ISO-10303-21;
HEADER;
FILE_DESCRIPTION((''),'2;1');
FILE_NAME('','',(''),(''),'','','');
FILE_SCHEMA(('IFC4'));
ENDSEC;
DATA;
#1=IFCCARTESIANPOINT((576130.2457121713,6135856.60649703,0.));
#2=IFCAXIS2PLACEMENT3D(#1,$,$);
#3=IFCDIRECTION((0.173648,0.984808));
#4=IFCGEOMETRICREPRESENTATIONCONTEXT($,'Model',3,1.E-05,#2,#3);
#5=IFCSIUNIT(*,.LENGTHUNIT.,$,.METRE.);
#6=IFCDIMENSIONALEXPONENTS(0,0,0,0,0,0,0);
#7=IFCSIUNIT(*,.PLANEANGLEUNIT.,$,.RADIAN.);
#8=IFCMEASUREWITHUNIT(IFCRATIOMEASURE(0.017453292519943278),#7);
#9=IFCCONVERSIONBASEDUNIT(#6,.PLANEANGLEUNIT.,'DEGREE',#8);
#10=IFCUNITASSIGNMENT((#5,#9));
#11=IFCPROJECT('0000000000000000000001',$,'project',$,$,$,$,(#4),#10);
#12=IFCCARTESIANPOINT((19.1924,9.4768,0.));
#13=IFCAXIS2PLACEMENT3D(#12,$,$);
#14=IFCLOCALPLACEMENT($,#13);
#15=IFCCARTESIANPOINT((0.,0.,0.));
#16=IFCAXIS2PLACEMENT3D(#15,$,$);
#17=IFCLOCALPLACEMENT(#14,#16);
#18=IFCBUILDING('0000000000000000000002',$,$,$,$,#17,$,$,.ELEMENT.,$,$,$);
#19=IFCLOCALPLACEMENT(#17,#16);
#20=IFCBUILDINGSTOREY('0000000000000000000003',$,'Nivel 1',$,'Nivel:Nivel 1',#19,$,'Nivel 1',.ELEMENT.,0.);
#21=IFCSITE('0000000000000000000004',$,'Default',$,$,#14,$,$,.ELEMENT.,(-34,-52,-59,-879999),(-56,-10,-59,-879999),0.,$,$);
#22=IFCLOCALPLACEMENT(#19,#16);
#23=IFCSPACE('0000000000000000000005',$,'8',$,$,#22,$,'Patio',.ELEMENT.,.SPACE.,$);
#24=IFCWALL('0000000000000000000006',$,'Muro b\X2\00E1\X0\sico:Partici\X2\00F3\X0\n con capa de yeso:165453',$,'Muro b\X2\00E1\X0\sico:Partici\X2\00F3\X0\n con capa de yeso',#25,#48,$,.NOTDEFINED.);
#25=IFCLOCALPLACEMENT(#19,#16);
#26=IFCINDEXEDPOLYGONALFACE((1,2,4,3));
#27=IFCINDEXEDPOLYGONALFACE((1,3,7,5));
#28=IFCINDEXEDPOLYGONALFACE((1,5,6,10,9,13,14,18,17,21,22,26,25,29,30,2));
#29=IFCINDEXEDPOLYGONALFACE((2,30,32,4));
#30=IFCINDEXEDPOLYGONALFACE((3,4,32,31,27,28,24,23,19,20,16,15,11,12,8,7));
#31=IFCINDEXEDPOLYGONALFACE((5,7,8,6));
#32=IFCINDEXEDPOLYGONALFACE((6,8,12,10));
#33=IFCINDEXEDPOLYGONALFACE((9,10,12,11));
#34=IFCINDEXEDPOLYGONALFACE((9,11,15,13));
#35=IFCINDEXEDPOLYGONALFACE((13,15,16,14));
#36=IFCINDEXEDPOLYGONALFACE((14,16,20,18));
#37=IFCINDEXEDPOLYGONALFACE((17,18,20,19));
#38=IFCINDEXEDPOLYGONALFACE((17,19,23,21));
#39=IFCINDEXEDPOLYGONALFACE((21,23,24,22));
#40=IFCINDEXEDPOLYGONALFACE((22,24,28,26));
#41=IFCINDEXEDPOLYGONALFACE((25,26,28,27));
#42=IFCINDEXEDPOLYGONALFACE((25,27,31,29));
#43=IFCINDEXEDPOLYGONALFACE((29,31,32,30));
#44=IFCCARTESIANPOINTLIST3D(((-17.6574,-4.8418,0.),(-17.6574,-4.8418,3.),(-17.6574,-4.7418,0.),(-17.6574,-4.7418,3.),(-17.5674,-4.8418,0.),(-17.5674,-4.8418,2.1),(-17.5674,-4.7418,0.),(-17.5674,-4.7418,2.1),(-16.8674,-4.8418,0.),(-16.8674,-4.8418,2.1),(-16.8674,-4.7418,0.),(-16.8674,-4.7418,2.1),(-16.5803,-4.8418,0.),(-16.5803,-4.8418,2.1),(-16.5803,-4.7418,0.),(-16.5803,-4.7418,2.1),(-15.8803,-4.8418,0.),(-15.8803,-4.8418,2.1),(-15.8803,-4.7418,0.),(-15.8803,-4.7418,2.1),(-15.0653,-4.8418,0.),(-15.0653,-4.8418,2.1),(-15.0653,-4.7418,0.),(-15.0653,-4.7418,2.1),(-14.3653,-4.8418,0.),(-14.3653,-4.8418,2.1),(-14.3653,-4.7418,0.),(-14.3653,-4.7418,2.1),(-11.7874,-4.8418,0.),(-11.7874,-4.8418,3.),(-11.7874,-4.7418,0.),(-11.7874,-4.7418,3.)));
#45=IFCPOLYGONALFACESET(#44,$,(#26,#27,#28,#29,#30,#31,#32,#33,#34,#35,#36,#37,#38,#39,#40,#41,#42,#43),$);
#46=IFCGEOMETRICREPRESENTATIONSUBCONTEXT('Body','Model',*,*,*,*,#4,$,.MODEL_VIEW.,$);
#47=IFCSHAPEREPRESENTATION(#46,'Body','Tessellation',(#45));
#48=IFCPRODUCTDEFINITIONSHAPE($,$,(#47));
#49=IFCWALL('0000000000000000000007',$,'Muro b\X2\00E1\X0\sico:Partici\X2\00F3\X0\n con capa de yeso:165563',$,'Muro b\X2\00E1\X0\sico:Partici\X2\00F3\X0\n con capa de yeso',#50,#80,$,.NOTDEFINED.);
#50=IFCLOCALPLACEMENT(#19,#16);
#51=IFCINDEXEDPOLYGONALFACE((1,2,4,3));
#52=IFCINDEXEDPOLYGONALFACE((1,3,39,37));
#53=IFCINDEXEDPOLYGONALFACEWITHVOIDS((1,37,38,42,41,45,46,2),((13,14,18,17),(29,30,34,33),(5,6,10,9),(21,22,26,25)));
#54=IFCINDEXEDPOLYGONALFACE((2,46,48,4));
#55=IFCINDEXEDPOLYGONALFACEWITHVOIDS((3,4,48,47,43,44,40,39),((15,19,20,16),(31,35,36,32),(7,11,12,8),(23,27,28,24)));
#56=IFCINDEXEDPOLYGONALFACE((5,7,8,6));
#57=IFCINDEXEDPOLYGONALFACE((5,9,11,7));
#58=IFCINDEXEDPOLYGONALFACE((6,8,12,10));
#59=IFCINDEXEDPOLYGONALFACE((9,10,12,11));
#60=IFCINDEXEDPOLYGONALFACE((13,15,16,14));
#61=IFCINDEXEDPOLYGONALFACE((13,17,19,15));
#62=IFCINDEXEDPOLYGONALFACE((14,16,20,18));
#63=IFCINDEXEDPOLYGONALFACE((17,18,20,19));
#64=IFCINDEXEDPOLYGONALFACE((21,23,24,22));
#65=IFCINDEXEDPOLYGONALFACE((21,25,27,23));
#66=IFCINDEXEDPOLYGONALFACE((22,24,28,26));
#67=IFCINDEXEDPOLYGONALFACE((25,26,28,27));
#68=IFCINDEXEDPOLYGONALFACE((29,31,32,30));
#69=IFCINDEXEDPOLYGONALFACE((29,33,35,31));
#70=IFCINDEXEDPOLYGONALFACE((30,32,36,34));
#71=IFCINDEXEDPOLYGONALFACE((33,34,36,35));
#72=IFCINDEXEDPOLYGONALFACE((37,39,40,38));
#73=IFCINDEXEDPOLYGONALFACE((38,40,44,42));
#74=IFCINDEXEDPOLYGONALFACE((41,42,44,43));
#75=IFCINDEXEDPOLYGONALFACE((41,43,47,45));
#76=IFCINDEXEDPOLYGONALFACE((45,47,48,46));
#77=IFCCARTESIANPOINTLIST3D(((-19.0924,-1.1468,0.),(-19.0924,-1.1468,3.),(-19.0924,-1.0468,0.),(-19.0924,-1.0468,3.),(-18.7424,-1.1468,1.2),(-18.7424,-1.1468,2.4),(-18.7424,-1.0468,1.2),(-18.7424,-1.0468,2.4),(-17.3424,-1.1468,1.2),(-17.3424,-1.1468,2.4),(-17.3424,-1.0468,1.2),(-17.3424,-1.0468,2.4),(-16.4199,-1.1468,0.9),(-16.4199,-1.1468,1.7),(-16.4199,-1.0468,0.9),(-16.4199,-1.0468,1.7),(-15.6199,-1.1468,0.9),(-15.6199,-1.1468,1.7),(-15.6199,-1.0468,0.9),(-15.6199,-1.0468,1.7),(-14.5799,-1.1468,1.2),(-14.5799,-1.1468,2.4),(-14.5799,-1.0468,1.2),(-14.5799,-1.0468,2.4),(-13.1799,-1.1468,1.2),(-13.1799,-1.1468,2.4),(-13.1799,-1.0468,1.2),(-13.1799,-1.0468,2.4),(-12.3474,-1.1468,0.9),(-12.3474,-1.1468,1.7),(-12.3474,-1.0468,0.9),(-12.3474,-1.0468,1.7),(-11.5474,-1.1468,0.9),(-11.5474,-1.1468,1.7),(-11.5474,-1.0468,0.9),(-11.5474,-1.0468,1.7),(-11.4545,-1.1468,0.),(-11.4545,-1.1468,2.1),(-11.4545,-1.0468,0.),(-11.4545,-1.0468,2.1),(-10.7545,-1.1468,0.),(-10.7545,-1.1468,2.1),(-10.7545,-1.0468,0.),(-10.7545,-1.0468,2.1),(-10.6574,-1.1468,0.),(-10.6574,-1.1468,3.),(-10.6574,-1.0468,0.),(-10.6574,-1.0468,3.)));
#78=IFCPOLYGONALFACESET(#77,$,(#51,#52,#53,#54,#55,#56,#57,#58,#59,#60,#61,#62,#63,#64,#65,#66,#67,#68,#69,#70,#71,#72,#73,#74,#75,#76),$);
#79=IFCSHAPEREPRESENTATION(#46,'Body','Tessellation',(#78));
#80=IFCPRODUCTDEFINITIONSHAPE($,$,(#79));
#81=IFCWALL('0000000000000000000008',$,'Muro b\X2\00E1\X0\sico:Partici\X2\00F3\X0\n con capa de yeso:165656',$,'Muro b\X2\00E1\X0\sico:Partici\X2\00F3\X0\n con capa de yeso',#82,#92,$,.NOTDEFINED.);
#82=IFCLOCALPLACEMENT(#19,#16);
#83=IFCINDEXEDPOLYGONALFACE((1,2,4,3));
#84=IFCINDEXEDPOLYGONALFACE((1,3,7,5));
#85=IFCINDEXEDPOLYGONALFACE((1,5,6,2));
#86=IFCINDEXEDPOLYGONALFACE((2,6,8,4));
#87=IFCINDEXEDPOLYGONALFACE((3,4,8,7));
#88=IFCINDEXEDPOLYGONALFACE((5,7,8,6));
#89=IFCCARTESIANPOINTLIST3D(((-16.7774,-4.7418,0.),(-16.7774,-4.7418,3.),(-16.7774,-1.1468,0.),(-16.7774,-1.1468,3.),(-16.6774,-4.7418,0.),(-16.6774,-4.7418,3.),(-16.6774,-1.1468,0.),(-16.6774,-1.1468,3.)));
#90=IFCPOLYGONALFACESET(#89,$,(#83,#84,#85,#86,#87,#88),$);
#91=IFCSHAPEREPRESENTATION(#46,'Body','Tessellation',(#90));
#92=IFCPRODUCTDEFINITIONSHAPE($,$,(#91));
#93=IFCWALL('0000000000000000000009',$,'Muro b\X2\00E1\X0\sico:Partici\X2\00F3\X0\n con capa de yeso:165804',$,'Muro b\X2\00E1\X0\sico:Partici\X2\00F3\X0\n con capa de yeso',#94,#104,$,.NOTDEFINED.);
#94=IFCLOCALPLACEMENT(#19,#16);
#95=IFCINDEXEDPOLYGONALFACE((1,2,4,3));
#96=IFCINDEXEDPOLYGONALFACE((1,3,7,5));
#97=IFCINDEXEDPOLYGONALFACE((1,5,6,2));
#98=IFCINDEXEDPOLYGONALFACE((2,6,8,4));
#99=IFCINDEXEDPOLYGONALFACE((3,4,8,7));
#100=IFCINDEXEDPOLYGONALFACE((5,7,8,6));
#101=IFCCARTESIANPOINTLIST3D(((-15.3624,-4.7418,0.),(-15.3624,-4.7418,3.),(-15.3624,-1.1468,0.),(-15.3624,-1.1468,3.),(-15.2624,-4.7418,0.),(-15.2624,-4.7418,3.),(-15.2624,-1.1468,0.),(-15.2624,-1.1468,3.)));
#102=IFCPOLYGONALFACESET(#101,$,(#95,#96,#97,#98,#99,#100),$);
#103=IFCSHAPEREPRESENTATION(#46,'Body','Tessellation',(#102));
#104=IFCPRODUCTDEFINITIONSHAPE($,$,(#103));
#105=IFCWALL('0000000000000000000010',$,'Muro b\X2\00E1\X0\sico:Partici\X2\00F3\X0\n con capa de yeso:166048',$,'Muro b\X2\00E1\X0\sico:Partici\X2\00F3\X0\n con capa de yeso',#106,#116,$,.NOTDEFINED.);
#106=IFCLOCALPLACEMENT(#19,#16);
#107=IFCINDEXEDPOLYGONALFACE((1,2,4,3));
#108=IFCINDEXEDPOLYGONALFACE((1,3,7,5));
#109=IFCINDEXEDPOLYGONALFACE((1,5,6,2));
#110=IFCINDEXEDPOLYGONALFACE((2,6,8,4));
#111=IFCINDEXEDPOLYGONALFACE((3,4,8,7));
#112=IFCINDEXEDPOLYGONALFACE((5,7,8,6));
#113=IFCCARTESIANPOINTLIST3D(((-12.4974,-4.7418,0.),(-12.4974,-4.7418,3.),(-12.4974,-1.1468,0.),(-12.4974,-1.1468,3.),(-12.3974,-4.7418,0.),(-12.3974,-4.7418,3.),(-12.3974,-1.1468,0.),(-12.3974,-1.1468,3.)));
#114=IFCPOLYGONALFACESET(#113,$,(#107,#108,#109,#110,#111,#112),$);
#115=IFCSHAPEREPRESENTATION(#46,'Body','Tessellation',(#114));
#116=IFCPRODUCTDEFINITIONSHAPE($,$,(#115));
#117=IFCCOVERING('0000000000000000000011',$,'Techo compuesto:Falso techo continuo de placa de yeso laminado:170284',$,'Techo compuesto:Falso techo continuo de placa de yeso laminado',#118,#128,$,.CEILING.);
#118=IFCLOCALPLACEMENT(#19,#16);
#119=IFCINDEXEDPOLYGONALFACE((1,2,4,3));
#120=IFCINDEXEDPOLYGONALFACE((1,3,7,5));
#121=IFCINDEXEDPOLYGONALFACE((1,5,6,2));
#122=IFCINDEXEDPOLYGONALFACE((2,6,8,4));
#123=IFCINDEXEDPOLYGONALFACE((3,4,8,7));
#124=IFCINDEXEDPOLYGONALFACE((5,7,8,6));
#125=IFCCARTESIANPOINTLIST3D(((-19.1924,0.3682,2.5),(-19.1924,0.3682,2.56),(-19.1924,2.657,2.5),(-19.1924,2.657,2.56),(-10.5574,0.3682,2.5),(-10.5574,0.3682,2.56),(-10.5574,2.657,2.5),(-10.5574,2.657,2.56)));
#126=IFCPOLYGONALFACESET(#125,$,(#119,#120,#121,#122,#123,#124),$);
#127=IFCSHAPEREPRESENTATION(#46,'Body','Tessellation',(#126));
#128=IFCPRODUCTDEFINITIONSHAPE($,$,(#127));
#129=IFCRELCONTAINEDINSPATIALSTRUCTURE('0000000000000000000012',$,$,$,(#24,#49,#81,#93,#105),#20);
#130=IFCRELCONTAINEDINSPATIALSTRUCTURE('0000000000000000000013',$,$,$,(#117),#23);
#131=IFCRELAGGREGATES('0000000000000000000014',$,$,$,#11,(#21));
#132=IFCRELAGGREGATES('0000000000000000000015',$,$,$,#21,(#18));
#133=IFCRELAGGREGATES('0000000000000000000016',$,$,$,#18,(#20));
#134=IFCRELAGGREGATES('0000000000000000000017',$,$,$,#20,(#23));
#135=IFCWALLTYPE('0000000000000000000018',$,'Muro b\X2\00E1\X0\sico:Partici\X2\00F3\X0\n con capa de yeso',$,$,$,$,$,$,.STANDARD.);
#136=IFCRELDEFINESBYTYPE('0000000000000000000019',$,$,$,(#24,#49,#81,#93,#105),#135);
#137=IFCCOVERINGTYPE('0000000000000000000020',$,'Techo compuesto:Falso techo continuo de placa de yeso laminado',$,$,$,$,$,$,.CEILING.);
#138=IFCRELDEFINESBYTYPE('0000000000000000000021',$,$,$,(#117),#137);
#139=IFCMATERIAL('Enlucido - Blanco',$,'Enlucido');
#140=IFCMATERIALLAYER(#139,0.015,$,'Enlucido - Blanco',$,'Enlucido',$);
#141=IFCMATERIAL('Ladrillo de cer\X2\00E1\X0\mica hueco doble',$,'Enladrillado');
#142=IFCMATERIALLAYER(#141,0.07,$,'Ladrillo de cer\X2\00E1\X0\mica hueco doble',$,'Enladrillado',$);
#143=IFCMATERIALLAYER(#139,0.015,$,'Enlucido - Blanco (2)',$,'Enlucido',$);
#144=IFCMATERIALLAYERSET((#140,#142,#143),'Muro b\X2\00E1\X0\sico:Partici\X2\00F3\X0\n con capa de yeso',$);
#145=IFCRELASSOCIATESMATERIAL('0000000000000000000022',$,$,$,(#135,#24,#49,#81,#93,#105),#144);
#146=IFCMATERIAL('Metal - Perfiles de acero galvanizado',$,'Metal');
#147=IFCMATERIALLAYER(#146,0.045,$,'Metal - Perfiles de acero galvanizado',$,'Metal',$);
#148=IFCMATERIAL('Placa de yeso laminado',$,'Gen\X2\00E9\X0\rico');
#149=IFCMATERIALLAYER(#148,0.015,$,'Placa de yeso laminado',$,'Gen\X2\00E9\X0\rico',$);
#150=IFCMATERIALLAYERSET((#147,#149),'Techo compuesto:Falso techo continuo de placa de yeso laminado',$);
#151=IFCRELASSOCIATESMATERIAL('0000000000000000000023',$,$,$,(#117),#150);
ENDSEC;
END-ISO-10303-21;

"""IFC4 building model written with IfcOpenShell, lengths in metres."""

from ifc_helpers import new_model, entity, si_unit, converted_unit, direction, frame, frame_2d, origin, place, context, subcontext, project, spatial, rectangle, extrude, material, layer, layer_set, layer_usage, type_object, element, save


model = new_model("IFC4")

# Units and contexts
model_context = context("Model", 3, precision=1e-05, world=frame((576130.2457121713, 6135856.60649703, 0.0)), true_north=direction((0.173648, 0.984808)))
body_context = subcontext(model_context, "Body", "Model", "MODEL_VIEW")
ifc_project = project(units=[si_unit("LENGTHUNIT", "METRE"), converted_unit("PLANEANGLEUNIT", "DEGREE", entity("IfcRatioMeasure", 0.017453292519943278), si_unit("PLANEANGLEUNIT", "RADIAN"), dimensions=[0, 0, 0, 0, 0, 0, 0])], contexts=[model_context])

# Site, building, storey
site_placement = place(None, frame((19.1924, 9.4768, 0.0)))
site = spatial("IfcSite", under=ifc_project, at=site_placement, Name="Default", CompositionType="ELEMENT", RefLatitude=(-34, -52, -59, -879999), RefLongitude=(-56, -10, -59, -879999), RefElevation=0.0)
building_placement = place(site_placement, origin())
building = spatial("IfcBuilding", under=site, at=building_placement, CompositionType="ELEMENT")
storey_placement = place(building_placement, origin())
storey = spatial("IfcBuildingStorey", under=building, at=storey_placement, Name="Nivel 1", ObjectType="Nivel:Nivel 1", LongName="Nivel 1", CompositionType="ELEMENT", Elevation=0.0)

# Shared definitions
ifc_material_1 = material(Name="Enlucido - Blanco", Category="Enlucido")
ifc_layer_1 = layer(ifc_material_1, 0.015, Name="Enlucido - Blanco", Category="Enlucido")
ifc_material_2 = material(Name="Ladrillo de cerámica hueco doble", Category="Enladrillado")
ifc_layer_2 = layer(ifc_material_2, 0.07, Name="Ladrillo de cerámica hueco doble", Category="Enladrillado")
ifc_layer_3 = layer(ifc_material_1, 0.015, Name="Enlucido - Blanco (2)", Category="Enlucido")
ifc_layer_set_1 = layer_set([ifc_layer_1, ifc_layer_2, ifc_layer_3], Name="Muro básico:Partición con capa de yeso")
ifc_layer_usage_1 = layer_usage(ifc_layer_set_1, "AXIS2", "NEGATIVE", 0.05)
wall_type = type_object("IfcWallType", Name="Muro básico:Partición con capa de yeso", PredefinedType="STANDARD", material=ifc_layer_set_1)

# Walls, openings
wall_1_placement = place(storey_placement, frame((-17.6574, -4.7918, 0.0)))
wall_1 = element("IfcWall", 1, at=wall_1_placement, inside=storey, type_object=wall_type, material=ifc_layer_usage_1, Name="Muro básico:Partición con capa de yeso:165453", ObjectType="Muro básico:Partición con capa de yeso", PredefinedType="NOTDEFINED", context=body_context, shape_type="SweptSolid", body=[
    extrude(rectangle(XDim=5.87, YDim=0.1, at=frame_2d((2.935, 0.0), x_axis=(1.0, 0.0))), origin(), (0.0, 0.0, 1.0), 3.0),
])
opening_1_placement = place(wall_1_placement, frame((0.09, -0.05, 0.0)))
element("IfcOpeningElement", 2, at=opening_1_placement, cuts=wall_1, PredefinedType="OPENING", context=body_context, shape_type="SweptSolid", body=[
    extrude(rectangle(XDim=2.1, YDim=0.7, at=frame_2d((1.05, 0.35), x_axis=(1.0, 0.0))), frame((0.0, 0.0, 0.0), z_axis=(0.0, 1.0, 0.0), x_axis=(0.0, 0.0, 1.0)), (0.0, 0.0, 1.0), 0.1),
])
opening_2_placement = place(wall_1_placement, frame((1.0771, -0.05, 0.0)))
element("IfcOpeningElement", 3, at=opening_2_placement, cuts=wall_1, PredefinedType="OPENING", context=body_context, shape_type="SweptSolid", body=[
    extrude(rectangle(XDim=2.1, YDim=0.7, at=frame_2d((1.05, 0.35), x_axis=(1.0, 0.0))), frame((0.0, 0.0, 0.0), z_axis=(0.0, 1.0, 0.0), x_axis=(0.0, 0.0, 1.0)), (0.0, 0.0, 1.0), 0.1),
])
opening_3_placement = place(wall_1_placement, frame((2.5921, -0.05, 0.0)))
element("IfcOpeningElement", 4, at=opening_3_placement, cuts=wall_1, PredefinedType="OPENING", context=body_context, shape_type="SweptSolid", body=[
    extrude(rectangle(XDim=2.1, YDim=0.7, at=frame_2d((1.05, 0.35), x_axis=(1.0, 0.0))), frame((0.0, 0.0, 0.0), z_axis=(0.0, 1.0, 0.0), x_axis=(0.0, 0.0, 1.0)), (0.0, 0.0, 1.0), 0.1),
])
wall_2_placement = place(storey_placement, frame((-19.0924, -1.0968, 0.0)))
wall_2 = element("IfcWall", 5, at=wall_2_placement, inside=storey, type_object=wall_type, material=ifc_layer_usage_1, Name="Muro básico:Partición con capa de yeso:165563", ObjectType="Muro básico:Partición con capa de yeso", PredefinedType="NOTDEFINED", context=body_context, shape_type="SweptSolid", body=[
    extrude(rectangle(XDim=8.435, YDim=0.1, at=frame_2d((4.2175, 0.0), x_axis=(-1.0, 0.0))), origin(), (0.0, 0.0, 1.0), 3.0),
])
opening_4_placement = place(wall_2_placement, frame((8.3379, 0.05, 0.0)))
element("IfcOpeningElement", 6, at=opening_4_placement, cuts=wall_2, PredefinedType="OPENING", context=body_context, shape_type="SweptSolid", body=[
    extrude(rectangle(XDim=2.1, YDim=0.7, at=frame_2d((1.05, 0.35), x_axis=(1.0, 0.0))), frame((0.0, 0.0, 0.0), z_axis=(0.0, -1.0, 0.0), x_axis=(0.0, 0.0, 1.0)), (0.0, 0.0, 1.0), 0.1),
])
opening_5_placement = place(wall_2_placement, frame((6.745, -0.05, 0.9)))
element("IfcOpeningElement", 7, at=opening_5_placement, cuts=wall_2, PredefinedType="OPENING", context=body_context, shape_type="SweptSolid", body=[
    extrude(rectangle(XDim=0.8, YDim=0.8, at=frame_2d((0.4, 0.4), x_axis=(1.0, 0.0))), frame((0.0, 0.0, 0.0), z_axis=(0.0, 1.0, 0.0), x_axis=(0.0, 0.0, 1.0)), (0.0, 0.0, 1.0), 0.1),
])
opening_6_placement = place(wall_2_placement, frame((0.35, -0.05, 1.2)))
element("IfcOpeningElement", 8, at=opening_6_placement, cuts=wall_2, PredefinedType="OPENING", context=body_context, shape_type="SweptSolid", body=[
    extrude(rectangle(XDim=1.2, YDim=1.4, at=frame_2d((0.6, 0.7), x_axis=(1.0, 0.0))), frame((0.0, 0.0, 0.0), z_axis=(0.0, 1.0, 0.0), x_axis=(0.0, 0.0, 1.0)), (0.0, 0.0, 1.0), 0.1),
])
opening_7_placement = place(wall_2_placement, frame((4.5125, -0.05, 1.2)))
element("IfcOpeningElement", 9, at=opening_7_placement, cuts=wall_2, PredefinedType="OPENING", context=body_context, shape_type="SweptSolid", body=[
    extrude(rectangle(XDim=1.2, YDim=1.4, at=frame_2d((0.6, 0.7), x_axis=(1.0, 0.0))), frame((0.0, 0.0, 0.0), z_axis=(0.0, 1.0, 0.0), x_axis=(0.0, 0.0, 1.0)), (0.0, 0.0, 1.0), 0.1),
])
opening_8_placement = place(wall_2_placement, frame((3.4725, 0.05, 0.9)))
element("IfcOpeningElement", 10, at=opening_8_placement, cuts=wall_2, PredefinedType="OPENING", context=body_context, shape_type="SweptSolid", body=[
    extrude(rectangle(XDim=0.8, YDim=0.8, at=frame_2d((0.4, 0.4), x_axis=(1.0, 0.0))), frame((0.0, 0.0, 0.0), z_axis=(0.0, -1.0, 0.0), x_axis=(0.0, 0.0, 1.0)), (0.0, 0.0, 1.0), 0.1),
])

# Walls
wall_3_placement = place(storey_placement, frame((-16.7274, -1.1468, 0.0), z_axis=(0.0, 0.0, 1.0), x_axis=(0.0, -1.0, 0.0)))
element("IfcWall", 11, at=wall_3_placement, inside=storey, type_object=wall_type, material=ifc_layer_usage_1, Name="Muro básico:Partición con capa de yeso:165656", ObjectType="Muro básico:Partición con capa de yeso", PredefinedType="NOTDEFINED", context=body_context, shape_type="SweptSolid", body=[
    extrude(rectangle(XDim=3.595, YDim=0.1, at=frame_2d((1.7975, 0.0), x_axis=(-1.0, 0.0))), origin(), (0.0, 0.0, 1.0), 3.0),
])
wall_4_placement = place(storey_placement, frame((-15.3124, -1.1468, 0.0), z_axis=(0.0, 0.0, 1.0), x_axis=(0.0, -1.0, 0.0)))
element("IfcWall", 12, at=wall_4_placement, inside=storey, type_object=wall_type, material=ifc_layer_usage_1, Name="Muro básico:Partición con capa de yeso:165804", ObjectType="Muro básico:Partición con capa de yeso", PredefinedType="NOTDEFINED", context=body_context, shape_type="SweptSolid", body=[
    extrude(rectangle(XDim=3.595, YDim=0.1, at=frame_2d((1.7975, 0.0), x_axis=(-1.0, 0.0))), origin(), (0.0, 0.0, 1.0), 3.0),
])
wall_5_placement = place(storey_placement, frame((-12.4474, -1.1468, 0.0), z_axis=(0.0, 0.0, 1.0), x_axis=(0.0, -1.0, 0.0)))
element("IfcWall", 13, at=wall_5_placement, inside=storey, type_object=wall_type, material=ifc_layer_usage_1, Name="Muro básico:Partición con capa de yeso:166048", ObjectType="Muro básico:Partición con capa de yeso", PredefinedType="NOTDEFINED", context=body_context, shape_type="SweptSolid", body=[
    extrude(rectangle(XDim=3.595, YDim=0.1, at=frame_2d((1.7975, 0.0), x_axis=(-1.0, 0.0))), origin(), (0.0, 0.0, 1.0), 3.0),
])

# Shared definitions
space_placement = place(storey_placement, origin())
space = spatial("IfcSpace", under=storey, at=space_placement, Name="8", LongName="Patio", CompositionType="ELEMENT", PredefinedType="SPACE")

# Covering
ifc_material_3 = material(Name="Metal - Perfiles de acero galvanizado", Category="Metal")
ifc_layer_4 = layer(ifc_material_3, 0.045, Name="Metal - Perfiles de acero galvanizado", Category="Metal")
ifc_material_4 = material(Name="Placa de yeso laminado", Category="Genérico")
ifc_layer_5 = layer(ifc_material_4, 0.015, Name="Placa de yeso laminado", Category="Genérico")
ifc_layer_set_2 = layer_set([ifc_layer_4, ifc_layer_5], Name="Techo compuesto:Falso techo continuo de placa de yeso laminado")
ifc_layer_usage_2 = layer_usage(ifc_layer_set_2, "AXIS3", "POSITIVE", 0.0)
covering_type = type_object("IfcCoveringType", Name="Techo compuesto:Falso techo continuo de placa de yeso laminado", PredefinedType="CEILING")
covering_placement = place(space_placement, frame((-19.1924, 0.3682, 2.5)))
element("IfcCovering", 14, at=covering_placement, inside=space, type_object=covering_type, material=ifc_layer_usage_2, Name="Techo compuesto:Falso techo continuo de placa de yeso laminado:170284", ObjectType="Techo compuesto:Falso techo continuo de placa de yeso laminado", PredefinedType="CEILING", context=body_context, shape_type="SweptSolid", body=[
    extrude(rectangle(XDim=8.635, YDim=2.2888, at=frame_2d((0.0, 0.0), x_axis=(1.0, 0.0))), frame((4.3175, 1.1444, 0.0)), (0.0, 0.0, 1.0), 0.06),
])

save(model, "model.ifc")
